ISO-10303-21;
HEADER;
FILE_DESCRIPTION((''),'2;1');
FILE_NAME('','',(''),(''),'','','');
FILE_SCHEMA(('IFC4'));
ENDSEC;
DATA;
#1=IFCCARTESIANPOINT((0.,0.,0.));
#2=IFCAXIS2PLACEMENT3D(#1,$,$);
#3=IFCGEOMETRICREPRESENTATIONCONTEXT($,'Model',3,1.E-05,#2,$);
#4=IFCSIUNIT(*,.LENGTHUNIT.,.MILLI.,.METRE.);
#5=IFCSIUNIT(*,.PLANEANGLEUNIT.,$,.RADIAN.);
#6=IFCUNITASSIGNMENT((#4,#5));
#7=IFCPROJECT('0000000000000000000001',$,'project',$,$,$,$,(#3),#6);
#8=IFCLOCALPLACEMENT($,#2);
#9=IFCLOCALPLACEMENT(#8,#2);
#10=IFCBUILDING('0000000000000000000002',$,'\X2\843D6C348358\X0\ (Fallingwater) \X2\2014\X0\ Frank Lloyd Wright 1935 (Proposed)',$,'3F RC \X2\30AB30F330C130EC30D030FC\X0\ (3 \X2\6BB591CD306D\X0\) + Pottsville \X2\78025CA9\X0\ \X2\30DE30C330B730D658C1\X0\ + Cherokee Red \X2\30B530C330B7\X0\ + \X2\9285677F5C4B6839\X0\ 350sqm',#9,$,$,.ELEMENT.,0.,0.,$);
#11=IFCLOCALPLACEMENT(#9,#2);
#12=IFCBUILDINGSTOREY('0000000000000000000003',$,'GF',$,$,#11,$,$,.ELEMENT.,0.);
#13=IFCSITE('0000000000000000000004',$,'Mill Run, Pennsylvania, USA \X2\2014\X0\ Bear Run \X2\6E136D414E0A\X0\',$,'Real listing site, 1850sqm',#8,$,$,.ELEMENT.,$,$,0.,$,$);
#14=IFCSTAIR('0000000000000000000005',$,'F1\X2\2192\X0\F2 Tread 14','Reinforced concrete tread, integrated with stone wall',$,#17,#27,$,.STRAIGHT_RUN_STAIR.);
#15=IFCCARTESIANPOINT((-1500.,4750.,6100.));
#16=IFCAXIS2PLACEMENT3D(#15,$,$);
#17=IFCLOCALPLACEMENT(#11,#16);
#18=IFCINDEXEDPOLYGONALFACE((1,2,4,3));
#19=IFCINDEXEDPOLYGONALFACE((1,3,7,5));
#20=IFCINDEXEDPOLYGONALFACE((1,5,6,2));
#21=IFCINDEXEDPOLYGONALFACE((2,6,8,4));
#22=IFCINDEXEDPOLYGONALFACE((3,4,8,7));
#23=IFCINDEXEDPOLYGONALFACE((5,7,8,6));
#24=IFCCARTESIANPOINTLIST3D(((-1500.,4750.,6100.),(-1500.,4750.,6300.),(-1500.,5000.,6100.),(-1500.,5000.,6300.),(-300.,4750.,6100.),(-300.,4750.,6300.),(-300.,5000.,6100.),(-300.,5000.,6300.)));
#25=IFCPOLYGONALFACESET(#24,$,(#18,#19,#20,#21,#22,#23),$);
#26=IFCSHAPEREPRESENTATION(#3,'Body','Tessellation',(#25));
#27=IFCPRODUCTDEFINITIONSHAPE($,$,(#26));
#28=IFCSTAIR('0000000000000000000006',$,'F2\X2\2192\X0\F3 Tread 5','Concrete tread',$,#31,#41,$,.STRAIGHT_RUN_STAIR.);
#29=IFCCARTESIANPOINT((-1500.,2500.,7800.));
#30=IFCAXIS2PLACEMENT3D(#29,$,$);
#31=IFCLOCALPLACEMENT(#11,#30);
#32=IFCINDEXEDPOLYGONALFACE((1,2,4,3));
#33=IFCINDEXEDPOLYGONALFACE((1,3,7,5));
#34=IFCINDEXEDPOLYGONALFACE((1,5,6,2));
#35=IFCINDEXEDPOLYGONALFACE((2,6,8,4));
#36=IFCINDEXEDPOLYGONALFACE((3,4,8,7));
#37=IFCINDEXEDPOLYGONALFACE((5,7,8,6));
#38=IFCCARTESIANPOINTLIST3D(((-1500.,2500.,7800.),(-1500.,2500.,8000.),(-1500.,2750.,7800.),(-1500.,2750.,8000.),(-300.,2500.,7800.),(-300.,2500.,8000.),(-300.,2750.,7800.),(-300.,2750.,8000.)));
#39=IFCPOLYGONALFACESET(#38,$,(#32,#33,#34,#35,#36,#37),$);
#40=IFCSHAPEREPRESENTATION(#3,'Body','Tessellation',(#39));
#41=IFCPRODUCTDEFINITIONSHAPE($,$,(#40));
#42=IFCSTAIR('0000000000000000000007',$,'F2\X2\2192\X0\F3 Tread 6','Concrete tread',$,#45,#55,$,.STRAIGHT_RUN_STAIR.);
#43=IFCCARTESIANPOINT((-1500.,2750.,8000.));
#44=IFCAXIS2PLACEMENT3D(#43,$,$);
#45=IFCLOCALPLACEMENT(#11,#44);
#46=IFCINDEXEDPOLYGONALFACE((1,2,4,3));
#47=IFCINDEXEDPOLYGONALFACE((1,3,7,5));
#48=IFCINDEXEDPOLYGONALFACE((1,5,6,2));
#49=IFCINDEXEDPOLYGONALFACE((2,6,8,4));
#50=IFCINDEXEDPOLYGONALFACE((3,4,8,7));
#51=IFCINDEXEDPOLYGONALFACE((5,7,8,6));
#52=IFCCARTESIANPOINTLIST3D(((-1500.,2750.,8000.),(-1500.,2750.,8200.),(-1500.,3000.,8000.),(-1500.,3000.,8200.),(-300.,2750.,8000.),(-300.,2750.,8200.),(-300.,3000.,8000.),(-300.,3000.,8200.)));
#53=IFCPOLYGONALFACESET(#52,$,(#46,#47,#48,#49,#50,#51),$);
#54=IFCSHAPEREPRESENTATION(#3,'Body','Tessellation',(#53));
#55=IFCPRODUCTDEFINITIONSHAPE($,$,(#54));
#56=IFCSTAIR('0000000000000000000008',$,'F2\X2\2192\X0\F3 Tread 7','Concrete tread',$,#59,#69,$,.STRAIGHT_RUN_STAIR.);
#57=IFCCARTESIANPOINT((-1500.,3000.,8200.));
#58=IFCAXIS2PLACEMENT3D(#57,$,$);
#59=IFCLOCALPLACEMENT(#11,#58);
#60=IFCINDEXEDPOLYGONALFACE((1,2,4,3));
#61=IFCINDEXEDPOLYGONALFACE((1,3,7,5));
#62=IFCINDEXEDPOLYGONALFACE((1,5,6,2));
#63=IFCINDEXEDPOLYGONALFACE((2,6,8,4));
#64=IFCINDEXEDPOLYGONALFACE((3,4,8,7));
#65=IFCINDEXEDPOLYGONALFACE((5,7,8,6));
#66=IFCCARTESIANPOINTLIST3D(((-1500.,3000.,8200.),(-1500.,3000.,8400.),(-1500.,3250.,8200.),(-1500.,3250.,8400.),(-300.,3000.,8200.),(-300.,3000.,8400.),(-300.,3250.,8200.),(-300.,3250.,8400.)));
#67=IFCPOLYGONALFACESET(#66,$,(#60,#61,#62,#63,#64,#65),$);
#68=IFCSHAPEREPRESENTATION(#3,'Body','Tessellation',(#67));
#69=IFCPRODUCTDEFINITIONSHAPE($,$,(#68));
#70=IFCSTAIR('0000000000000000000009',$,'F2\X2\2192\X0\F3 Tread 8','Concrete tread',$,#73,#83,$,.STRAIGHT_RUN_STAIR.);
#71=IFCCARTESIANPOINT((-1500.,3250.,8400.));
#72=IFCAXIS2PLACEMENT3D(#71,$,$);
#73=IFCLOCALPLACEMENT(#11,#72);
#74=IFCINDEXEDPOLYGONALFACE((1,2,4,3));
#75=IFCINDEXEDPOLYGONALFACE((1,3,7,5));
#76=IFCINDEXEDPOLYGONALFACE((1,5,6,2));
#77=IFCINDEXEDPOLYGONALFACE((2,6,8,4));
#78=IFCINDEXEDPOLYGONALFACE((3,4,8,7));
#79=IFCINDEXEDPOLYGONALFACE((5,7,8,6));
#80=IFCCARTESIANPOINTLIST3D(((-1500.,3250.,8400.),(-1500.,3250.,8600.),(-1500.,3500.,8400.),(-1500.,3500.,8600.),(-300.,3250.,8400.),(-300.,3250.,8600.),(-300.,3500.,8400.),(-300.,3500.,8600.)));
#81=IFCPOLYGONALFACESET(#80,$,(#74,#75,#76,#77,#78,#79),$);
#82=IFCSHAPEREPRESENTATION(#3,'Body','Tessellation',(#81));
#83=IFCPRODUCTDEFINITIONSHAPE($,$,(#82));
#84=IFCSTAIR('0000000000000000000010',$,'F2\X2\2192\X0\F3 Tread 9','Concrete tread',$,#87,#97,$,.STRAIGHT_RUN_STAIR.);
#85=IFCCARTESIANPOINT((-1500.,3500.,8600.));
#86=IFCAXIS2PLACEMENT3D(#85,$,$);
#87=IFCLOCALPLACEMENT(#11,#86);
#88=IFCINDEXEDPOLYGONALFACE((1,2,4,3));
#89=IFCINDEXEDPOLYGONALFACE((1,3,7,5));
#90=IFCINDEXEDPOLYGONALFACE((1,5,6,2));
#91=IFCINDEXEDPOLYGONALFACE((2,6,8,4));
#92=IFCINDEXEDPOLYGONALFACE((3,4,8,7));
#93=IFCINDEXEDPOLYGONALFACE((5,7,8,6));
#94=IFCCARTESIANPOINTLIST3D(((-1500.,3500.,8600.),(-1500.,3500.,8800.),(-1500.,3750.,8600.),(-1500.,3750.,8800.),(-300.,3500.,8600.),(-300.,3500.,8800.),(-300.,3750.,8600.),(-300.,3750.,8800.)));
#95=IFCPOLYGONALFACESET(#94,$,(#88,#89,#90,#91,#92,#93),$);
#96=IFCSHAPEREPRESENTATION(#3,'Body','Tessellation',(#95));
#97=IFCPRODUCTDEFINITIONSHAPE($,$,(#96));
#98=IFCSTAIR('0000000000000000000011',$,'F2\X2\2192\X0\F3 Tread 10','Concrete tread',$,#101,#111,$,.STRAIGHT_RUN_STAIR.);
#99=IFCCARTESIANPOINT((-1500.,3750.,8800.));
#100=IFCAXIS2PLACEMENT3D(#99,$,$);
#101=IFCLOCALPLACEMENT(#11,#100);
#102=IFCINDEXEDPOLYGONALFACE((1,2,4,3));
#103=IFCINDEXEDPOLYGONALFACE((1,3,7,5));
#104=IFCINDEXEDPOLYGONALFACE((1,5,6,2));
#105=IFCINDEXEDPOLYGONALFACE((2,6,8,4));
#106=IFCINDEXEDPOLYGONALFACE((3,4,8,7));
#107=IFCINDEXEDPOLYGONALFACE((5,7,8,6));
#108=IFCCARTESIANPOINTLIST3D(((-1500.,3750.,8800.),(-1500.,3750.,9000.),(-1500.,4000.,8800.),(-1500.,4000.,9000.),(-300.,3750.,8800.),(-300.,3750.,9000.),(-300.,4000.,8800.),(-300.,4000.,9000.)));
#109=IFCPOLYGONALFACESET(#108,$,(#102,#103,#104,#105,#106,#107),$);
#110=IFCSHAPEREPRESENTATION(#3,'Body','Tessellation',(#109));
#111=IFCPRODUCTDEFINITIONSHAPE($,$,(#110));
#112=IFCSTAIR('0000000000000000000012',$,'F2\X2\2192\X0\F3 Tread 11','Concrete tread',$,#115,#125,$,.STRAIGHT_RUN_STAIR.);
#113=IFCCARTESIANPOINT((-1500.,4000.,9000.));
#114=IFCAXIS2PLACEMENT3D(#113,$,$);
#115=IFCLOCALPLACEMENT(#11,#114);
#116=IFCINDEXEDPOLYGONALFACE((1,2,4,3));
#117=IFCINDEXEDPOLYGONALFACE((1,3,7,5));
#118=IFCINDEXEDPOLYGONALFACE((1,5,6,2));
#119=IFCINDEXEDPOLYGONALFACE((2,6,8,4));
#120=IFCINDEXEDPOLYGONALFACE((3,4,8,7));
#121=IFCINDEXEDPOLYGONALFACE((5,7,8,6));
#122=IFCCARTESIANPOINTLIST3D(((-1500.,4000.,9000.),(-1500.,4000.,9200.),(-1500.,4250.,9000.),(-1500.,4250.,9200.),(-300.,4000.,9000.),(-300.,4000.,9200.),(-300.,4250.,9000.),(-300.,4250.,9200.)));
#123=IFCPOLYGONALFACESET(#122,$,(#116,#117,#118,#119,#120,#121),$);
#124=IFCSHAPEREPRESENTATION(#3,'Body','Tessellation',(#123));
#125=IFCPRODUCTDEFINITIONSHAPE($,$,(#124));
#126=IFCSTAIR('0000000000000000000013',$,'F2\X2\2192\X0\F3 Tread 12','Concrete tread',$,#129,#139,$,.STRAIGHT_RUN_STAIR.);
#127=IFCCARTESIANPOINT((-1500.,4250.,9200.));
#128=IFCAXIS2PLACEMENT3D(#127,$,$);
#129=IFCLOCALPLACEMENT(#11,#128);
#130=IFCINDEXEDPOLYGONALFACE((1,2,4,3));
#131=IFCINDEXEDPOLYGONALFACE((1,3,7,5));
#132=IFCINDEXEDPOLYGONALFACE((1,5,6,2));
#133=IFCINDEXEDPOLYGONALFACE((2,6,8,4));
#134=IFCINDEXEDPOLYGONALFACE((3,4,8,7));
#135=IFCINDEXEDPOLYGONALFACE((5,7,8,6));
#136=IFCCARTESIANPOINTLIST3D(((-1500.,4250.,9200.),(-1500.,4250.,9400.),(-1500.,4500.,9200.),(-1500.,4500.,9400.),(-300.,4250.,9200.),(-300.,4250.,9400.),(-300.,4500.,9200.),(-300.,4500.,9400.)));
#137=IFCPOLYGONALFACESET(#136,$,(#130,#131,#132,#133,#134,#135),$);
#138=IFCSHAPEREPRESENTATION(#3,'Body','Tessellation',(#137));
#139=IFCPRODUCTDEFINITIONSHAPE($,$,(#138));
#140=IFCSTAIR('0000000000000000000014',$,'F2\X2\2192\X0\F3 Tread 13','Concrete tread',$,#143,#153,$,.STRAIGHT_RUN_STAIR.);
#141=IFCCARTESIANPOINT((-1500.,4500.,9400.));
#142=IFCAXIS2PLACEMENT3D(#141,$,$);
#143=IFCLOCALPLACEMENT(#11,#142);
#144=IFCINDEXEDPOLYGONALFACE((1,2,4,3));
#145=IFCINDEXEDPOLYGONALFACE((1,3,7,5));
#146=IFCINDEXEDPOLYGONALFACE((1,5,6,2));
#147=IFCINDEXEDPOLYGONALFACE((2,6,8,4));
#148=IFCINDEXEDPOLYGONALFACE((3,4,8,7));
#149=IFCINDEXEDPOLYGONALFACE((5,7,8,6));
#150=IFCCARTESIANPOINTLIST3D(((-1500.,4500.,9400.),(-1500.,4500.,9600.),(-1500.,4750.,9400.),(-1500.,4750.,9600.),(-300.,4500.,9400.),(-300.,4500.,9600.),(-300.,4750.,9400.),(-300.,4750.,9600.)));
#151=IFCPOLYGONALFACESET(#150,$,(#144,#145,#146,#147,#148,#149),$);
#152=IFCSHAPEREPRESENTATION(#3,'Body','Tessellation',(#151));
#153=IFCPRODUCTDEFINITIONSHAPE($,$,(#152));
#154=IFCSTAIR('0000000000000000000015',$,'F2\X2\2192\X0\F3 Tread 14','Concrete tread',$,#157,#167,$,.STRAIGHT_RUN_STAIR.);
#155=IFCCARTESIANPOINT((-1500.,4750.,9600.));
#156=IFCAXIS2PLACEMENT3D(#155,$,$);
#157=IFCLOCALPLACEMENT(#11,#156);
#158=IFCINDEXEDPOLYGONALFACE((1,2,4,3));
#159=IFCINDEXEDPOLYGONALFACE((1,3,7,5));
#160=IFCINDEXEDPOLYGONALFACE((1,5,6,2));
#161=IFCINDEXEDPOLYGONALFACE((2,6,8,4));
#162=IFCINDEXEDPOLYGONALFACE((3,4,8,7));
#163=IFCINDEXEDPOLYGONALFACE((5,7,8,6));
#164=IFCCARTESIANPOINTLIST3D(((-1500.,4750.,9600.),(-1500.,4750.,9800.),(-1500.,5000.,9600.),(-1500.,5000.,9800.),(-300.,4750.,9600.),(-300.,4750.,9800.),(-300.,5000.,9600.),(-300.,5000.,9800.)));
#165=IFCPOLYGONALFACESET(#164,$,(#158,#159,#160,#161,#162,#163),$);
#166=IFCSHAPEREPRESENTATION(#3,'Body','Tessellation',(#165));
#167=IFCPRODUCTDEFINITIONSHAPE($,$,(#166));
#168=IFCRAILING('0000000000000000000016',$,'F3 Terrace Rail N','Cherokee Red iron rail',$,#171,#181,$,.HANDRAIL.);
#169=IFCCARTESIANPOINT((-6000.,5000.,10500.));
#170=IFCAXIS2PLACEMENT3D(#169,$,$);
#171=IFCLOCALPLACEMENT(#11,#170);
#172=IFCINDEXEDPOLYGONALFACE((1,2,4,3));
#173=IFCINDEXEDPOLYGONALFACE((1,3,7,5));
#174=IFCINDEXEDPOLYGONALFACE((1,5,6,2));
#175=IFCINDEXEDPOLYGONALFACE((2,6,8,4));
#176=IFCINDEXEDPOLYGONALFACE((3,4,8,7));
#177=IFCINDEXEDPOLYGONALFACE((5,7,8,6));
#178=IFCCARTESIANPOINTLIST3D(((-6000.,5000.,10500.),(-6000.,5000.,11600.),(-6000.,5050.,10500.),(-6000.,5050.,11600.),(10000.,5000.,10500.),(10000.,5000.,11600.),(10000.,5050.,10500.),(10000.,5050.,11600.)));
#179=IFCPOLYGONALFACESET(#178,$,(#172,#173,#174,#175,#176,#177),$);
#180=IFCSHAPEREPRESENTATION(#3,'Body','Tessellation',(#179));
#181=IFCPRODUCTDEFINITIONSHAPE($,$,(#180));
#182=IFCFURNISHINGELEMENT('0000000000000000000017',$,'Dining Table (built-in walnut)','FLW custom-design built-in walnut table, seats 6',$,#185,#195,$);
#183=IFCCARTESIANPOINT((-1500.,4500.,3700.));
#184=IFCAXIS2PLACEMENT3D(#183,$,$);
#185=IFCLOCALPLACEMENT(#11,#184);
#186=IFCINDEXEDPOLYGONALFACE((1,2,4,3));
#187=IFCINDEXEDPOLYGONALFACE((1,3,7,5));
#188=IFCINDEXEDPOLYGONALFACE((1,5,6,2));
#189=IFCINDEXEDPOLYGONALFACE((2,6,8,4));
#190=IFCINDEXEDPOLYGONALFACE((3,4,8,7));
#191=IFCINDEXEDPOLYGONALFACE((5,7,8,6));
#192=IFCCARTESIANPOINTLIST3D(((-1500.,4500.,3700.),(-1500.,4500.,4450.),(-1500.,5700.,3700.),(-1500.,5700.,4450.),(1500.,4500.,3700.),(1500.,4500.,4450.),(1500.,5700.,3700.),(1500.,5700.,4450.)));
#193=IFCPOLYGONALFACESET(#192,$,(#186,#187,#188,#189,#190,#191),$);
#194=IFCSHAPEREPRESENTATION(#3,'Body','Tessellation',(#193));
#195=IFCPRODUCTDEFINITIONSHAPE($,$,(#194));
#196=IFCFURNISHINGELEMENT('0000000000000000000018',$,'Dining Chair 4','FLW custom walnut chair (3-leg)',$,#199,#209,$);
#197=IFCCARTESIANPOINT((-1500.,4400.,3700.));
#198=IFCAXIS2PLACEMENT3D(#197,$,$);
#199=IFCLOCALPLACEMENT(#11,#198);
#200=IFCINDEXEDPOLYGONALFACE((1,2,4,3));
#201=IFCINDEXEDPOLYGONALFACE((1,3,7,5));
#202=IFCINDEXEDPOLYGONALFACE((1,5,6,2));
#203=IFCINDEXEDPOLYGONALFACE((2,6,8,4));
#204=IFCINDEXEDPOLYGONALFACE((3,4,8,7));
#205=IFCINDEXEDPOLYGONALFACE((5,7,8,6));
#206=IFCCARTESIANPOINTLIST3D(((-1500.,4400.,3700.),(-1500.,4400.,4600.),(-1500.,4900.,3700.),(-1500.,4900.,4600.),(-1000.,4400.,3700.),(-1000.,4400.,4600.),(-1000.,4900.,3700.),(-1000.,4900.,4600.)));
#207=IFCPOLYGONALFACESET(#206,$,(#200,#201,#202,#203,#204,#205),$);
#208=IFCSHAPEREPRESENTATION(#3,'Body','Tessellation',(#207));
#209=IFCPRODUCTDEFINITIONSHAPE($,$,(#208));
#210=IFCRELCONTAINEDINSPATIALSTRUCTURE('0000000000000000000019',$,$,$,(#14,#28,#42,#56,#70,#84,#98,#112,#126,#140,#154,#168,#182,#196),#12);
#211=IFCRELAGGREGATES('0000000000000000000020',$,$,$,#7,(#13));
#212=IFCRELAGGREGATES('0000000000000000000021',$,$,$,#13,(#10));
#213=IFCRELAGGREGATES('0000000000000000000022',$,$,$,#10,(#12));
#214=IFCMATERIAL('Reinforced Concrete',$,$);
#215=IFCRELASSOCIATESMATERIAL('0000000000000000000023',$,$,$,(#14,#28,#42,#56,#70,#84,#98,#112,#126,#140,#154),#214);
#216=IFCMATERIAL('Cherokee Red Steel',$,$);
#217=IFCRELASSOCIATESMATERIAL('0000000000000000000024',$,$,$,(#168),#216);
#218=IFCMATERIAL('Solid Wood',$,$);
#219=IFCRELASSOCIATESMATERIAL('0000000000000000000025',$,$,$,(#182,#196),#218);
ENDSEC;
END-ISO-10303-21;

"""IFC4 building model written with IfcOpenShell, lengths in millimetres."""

from ifc_helpers import new_model, si_unit, frame, frame_2d, origin, place, context, project, spatial, rectangle, extrude, material, element, save


model = new_model("IFC4")

# Units and contexts
model_context = context("Model", 3, precision=1e-05, world=origin())
ifc_project = project(units=[si_unit("LENGTHUNIT", "METRE", prefix="MILLI"), si_unit("PLANEANGLEUNIT", "RADIAN")], contexts=[model_context])

# Site, building, storey
site_placement = place(None, origin())
site = spatial("IfcSite", under=ifc_project, at=site_placement, Name="Mill Run, Pennsylvania, USA — Bear Run 渓流上", ObjectType="Real listing site, 1850sqm", CompositionType="ELEMENT", RefElevation=0.0)
building_placement = place(site_placement, origin())
building = spatial("IfcBuilding", under=site, at=building_placement, Name="落水荘 (Fallingwater) — Frank Lloyd Wright 1935 (Proposed)", ObjectType="3F RC カンチレバー (3 段重ね) + Pottsville 砂岩 マッシブ壁 + Cherokee Red サッシ + 銅板屋根 350sqm", CompositionType="ELEMENT", ElevationOfRefHeight=0.0, ElevationOfTerrain=0.0)
storey_placement = place(building_placement, origin())
storey = spatial("IfcBuildingStorey", under=building, at=storey_placement, Name="GF", CompositionType="ELEMENT", Elevation=0.0)

# Stairs
ifc_material_1 = material(Name="Reinforced Concrete")
stair_1_placement = place(storey_placement, frame((-1500.0, 4750.0, 6100.0)))
element("IfcStair", 1, at=stair_1_placement, inside=storey, material=ifc_material_1, Name="F1→F2 Tread 14", Description="Reinforced concrete tread, integrated with stone wall", PredefinedType="STRAIGHT_RUN_STAIR", context=model_context, shape_type="SweptSolid", body=[
    extrude(rectangle(XDim=1200.0, YDim=250.0, at=frame_2d((600.0, 125.0))), frame((-1500.0, 4750.0, 6100.0)), (0.0, 0.0, 1.0), 200.0),
])
stair_2_placement = place(storey_placement, frame((-1500.0, 2500.0, 7800.0)))
element("IfcStair", 2, at=stair_2_placement, inside=storey, material=ifc_material_1, Name="F2→F3 Tread 5", Description="Concrete tread", PredefinedType="STRAIGHT_RUN_STAIR", context=model_context, shape_type="SweptSolid", body=[
    extrude(rectangle(XDim=1200.0, YDim=250.0, at=frame_2d((600.0, 125.0))), frame((-1500.0, 2500.0, 7800.0)), (0.0, 0.0, 1.0), 200.0),
])
stair_3_placement = place(storey_placement, frame((-1500.0, 2750.0, 8000.0)))
element("IfcStair", 3, at=stair_3_placement, inside=storey, material=ifc_material_1, Name="F2→F3 Tread 6", Description="Concrete tread", PredefinedType="STRAIGHT_RUN_STAIR", context=model_context, shape_type="SweptSolid", body=[
    extrude(rectangle(XDim=1200.0, YDim=250.0, at=frame_2d((600.0, 125.0))), frame((-1500.0, 2750.0, 8000.0)), (0.0, 0.0, 1.0), 200.0),
])
stair_4_placement = place(storey_placement, frame((-1500.0, 3000.0, 8200.0)))
element("IfcStair", 4, at=stair_4_placement, inside=storey, material=ifc_material_1, Name="F2→F3 Tread 7", Description="Concrete tread", PredefinedType="STRAIGHT_RUN_STAIR", context=model_context, shape_type="SweptSolid", body=[
    extrude(rectangle(XDim=1200.0, YDim=250.0, at=frame_2d((600.0, 125.0))), frame((-1500.0, 3000.0, 8200.0)), (0.0, 0.0, 1.0), 200.0),
])
stair_5_placement = place(storey_placement, frame((-1500.0, 3250.0, 8400.0)))
element("IfcStair", 5, at=stair_5_placement, inside=storey, material=ifc_material_1, Name="F2→F3 Tread 8", Description="Concrete tread", PredefinedType="STRAIGHT_RUN_STAIR", context=model_context, shape_type="SweptSolid", body=[
    extrude(rectangle(XDim=1200.0, YDim=250.0, at=frame_2d((600.0, 125.0))), frame((-1500.0, 3250.0, 8400.0)), (0.0, 0.0, 1.0), 200.0),
])
stair_6_placement = place(storey_placement, frame((-1500.0, 3500.0, 8600.0)))
element("IfcStair", 6, at=stair_6_placement, inside=storey, material=ifc_material_1, Name="F2→F3 Tread 9", Description="Concrete tread", PredefinedType="STRAIGHT_RUN_STAIR", context=model_context, shape_type="SweptSolid", body=[
    extrude(rectangle(XDim=1200.0, YDim=250.0, at=frame_2d((600.0, 125.0))), frame((-1500.0, 3500.0, 8600.0)), (0.0, 0.0, 1.0), 200.0),
])
stair_7_placement = place(storey_placement, frame((-1500.0, 3750.0, 8800.0)))
element("IfcStair", 7, at=stair_7_placement, inside=storey, material=ifc_material_1, Name="F2→F3 Tread 10", Description="Concrete tread", PredefinedType="STRAIGHT_RUN_STAIR", context=model_context, shape_type="SweptSolid", body=[
    extrude(rectangle(XDim=1200.0, YDim=250.0, at=frame_2d((600.0, 125.0))), frame((-1500.0, 3750.0, 8800.0)), (0.0, 0.0, 1.0), 200.0),
])
stair_8_placement = place(storey_placement, frame((-1500.0, 4000.0, 9000.0)))
element("IfcStair", 8, at=stair_8_placement, inside=storey, material=ifc_material_1, Name="F2→F3 Tread 11", Description="Concrete tread", PredefinedType="STRAIGHT_RUN_STAIR", context=model_context, shape_type="SweptSolid", body=[
    extrude(rectangle(XDim=1200.0, YDim=250.0, at=frame_2d((600.0, 125.0))), frame((-1500.0, 4000.0, 9000.0)), (0.0, 0.0, 1.0), 200.0),
])
stair_9_placement = place(storey_placement, frame((-1500.0, 4250.0, 9200.0)))
element("IfcStair", 9, at=stair_9_placement, inside=storey, material=ifc_material_1, Name="F2→F3 Tread 12", Description="Concrete tread", PredefinedType="STRAIGHT_RUN_STAIR", context=model_context, shape_type="SweptSolid", body=[
    extrude(rectangle(XDim=1200.0, YDim=250.0, at=frame_2d((600.0, 125.0))), frame((-1500.0, 4250.0, 9200.0)), (0.0, 0.0, 1.0), 200.0),
])
stair_10_placement = place(storey_placement, frame((-1500.0, 4500.0, 9400.0)))
element("IfcStair", 10, at=stair_10_placement, inside=storey, material=ifc_material_1, Name="F2→F3 Tread 13", Description="Concrete tread", PredefinedType="STRAIGHT_RUN_STAIR", context=model_context, shape_type="SweptSolid", body=[
    extrude(rectangle(XDim=1200.0, YDim=250.0, at=frame_2d((600.0, 125.0))), frame((-1500.0, 4500.0, 9400.0)), (0.0, 0.0, 1.0), 200.0),
])
stair_11_placement = place(storey_placement, frame((-1500.0, 4750.0, 9600.0)))
element("IfcStair", 11, at=stair_11_placement, inside=storey, material=ifc_material_1, Name="F2→F3 Tread 14", Description="Concrete tread", PredefinedType="STRAIGHT_RUN_STAIR", context=model_context, shape_type="SweptSolid", body=[
    extrude(rectangle(XDim=1200.0, YDim=250.0, at=frame_2d((600.0, 125.0))), frame((-1500.0, 4750.0, 9600.0)), (0.0, 0.0, 1.0), 200.0),
])

# Railing
ifc_material_2 = material(Name="Cherokee Red Steel")
railing_placement = place(storey_placement, frame((-6000.0, 5000.0, 10500.0)))
element("IfcRailing", 12, at=railing_placement, inside=storey, material=ifc_material_2, Name="F3 Terrace Rail N", Description="Cherokee Red iron rail", PredefinedType="HANDRAIL", context=model_context, shape_type="SweptSolid", body=[
    extrude(rectangle(XDim=16000.0, YDim=50.0, at=frame_2d((8000.0, 25.0))), frame((-6000.0, 5000.0, 10500.0)), (0.0, 0.0, 1.0), 1100.0),
])

# Furnishing elements
ifc_material_3 = material(Name="Solid Wood")
furnishing_1_placement = place(storey_placement, frame((-1500.0, 4500.0, 3700.0)))
element("IfcFurnishingElement", 13, at=furnishing_1_placement, inside=storey, material=ifc_material_3, Name="Dining Table (built-in walnut)", Description="FLW custom-design built-in walnut table, seats 6", context=model_context, shape_type="SweptSolid", body=[
    extrude(rectangle(XDim=3000.0, YDim=1200.0, at=frame_2d((1500.0, 600.0))), frame((-1500.0, 4500.0, 3700.0)), (0.0, 0.0, 1.0), 750.0),
])
furnishing_2_placement = place(storey_placement, frame((-1500.0, 4400.0, 3700.0)))
element("IfcFurnishingElement", 14, at=furnishing_2_placement, inside=storey, material=ifc_material_3, Name="Dining Chair 4", Description="FLW custom walnut chair (3-leg)", context=model_context, shape_type="SweptSolid", body=[
    extrude(rectangle(XDim=500.0, YDim=500.0, at=frame_2d((250.0, 250.0))), frame((-1500.0, 4400.0, 3700.0)), (0.0, 0.0, 1.0), 900.0),
])

save(model, "model.ifc")
